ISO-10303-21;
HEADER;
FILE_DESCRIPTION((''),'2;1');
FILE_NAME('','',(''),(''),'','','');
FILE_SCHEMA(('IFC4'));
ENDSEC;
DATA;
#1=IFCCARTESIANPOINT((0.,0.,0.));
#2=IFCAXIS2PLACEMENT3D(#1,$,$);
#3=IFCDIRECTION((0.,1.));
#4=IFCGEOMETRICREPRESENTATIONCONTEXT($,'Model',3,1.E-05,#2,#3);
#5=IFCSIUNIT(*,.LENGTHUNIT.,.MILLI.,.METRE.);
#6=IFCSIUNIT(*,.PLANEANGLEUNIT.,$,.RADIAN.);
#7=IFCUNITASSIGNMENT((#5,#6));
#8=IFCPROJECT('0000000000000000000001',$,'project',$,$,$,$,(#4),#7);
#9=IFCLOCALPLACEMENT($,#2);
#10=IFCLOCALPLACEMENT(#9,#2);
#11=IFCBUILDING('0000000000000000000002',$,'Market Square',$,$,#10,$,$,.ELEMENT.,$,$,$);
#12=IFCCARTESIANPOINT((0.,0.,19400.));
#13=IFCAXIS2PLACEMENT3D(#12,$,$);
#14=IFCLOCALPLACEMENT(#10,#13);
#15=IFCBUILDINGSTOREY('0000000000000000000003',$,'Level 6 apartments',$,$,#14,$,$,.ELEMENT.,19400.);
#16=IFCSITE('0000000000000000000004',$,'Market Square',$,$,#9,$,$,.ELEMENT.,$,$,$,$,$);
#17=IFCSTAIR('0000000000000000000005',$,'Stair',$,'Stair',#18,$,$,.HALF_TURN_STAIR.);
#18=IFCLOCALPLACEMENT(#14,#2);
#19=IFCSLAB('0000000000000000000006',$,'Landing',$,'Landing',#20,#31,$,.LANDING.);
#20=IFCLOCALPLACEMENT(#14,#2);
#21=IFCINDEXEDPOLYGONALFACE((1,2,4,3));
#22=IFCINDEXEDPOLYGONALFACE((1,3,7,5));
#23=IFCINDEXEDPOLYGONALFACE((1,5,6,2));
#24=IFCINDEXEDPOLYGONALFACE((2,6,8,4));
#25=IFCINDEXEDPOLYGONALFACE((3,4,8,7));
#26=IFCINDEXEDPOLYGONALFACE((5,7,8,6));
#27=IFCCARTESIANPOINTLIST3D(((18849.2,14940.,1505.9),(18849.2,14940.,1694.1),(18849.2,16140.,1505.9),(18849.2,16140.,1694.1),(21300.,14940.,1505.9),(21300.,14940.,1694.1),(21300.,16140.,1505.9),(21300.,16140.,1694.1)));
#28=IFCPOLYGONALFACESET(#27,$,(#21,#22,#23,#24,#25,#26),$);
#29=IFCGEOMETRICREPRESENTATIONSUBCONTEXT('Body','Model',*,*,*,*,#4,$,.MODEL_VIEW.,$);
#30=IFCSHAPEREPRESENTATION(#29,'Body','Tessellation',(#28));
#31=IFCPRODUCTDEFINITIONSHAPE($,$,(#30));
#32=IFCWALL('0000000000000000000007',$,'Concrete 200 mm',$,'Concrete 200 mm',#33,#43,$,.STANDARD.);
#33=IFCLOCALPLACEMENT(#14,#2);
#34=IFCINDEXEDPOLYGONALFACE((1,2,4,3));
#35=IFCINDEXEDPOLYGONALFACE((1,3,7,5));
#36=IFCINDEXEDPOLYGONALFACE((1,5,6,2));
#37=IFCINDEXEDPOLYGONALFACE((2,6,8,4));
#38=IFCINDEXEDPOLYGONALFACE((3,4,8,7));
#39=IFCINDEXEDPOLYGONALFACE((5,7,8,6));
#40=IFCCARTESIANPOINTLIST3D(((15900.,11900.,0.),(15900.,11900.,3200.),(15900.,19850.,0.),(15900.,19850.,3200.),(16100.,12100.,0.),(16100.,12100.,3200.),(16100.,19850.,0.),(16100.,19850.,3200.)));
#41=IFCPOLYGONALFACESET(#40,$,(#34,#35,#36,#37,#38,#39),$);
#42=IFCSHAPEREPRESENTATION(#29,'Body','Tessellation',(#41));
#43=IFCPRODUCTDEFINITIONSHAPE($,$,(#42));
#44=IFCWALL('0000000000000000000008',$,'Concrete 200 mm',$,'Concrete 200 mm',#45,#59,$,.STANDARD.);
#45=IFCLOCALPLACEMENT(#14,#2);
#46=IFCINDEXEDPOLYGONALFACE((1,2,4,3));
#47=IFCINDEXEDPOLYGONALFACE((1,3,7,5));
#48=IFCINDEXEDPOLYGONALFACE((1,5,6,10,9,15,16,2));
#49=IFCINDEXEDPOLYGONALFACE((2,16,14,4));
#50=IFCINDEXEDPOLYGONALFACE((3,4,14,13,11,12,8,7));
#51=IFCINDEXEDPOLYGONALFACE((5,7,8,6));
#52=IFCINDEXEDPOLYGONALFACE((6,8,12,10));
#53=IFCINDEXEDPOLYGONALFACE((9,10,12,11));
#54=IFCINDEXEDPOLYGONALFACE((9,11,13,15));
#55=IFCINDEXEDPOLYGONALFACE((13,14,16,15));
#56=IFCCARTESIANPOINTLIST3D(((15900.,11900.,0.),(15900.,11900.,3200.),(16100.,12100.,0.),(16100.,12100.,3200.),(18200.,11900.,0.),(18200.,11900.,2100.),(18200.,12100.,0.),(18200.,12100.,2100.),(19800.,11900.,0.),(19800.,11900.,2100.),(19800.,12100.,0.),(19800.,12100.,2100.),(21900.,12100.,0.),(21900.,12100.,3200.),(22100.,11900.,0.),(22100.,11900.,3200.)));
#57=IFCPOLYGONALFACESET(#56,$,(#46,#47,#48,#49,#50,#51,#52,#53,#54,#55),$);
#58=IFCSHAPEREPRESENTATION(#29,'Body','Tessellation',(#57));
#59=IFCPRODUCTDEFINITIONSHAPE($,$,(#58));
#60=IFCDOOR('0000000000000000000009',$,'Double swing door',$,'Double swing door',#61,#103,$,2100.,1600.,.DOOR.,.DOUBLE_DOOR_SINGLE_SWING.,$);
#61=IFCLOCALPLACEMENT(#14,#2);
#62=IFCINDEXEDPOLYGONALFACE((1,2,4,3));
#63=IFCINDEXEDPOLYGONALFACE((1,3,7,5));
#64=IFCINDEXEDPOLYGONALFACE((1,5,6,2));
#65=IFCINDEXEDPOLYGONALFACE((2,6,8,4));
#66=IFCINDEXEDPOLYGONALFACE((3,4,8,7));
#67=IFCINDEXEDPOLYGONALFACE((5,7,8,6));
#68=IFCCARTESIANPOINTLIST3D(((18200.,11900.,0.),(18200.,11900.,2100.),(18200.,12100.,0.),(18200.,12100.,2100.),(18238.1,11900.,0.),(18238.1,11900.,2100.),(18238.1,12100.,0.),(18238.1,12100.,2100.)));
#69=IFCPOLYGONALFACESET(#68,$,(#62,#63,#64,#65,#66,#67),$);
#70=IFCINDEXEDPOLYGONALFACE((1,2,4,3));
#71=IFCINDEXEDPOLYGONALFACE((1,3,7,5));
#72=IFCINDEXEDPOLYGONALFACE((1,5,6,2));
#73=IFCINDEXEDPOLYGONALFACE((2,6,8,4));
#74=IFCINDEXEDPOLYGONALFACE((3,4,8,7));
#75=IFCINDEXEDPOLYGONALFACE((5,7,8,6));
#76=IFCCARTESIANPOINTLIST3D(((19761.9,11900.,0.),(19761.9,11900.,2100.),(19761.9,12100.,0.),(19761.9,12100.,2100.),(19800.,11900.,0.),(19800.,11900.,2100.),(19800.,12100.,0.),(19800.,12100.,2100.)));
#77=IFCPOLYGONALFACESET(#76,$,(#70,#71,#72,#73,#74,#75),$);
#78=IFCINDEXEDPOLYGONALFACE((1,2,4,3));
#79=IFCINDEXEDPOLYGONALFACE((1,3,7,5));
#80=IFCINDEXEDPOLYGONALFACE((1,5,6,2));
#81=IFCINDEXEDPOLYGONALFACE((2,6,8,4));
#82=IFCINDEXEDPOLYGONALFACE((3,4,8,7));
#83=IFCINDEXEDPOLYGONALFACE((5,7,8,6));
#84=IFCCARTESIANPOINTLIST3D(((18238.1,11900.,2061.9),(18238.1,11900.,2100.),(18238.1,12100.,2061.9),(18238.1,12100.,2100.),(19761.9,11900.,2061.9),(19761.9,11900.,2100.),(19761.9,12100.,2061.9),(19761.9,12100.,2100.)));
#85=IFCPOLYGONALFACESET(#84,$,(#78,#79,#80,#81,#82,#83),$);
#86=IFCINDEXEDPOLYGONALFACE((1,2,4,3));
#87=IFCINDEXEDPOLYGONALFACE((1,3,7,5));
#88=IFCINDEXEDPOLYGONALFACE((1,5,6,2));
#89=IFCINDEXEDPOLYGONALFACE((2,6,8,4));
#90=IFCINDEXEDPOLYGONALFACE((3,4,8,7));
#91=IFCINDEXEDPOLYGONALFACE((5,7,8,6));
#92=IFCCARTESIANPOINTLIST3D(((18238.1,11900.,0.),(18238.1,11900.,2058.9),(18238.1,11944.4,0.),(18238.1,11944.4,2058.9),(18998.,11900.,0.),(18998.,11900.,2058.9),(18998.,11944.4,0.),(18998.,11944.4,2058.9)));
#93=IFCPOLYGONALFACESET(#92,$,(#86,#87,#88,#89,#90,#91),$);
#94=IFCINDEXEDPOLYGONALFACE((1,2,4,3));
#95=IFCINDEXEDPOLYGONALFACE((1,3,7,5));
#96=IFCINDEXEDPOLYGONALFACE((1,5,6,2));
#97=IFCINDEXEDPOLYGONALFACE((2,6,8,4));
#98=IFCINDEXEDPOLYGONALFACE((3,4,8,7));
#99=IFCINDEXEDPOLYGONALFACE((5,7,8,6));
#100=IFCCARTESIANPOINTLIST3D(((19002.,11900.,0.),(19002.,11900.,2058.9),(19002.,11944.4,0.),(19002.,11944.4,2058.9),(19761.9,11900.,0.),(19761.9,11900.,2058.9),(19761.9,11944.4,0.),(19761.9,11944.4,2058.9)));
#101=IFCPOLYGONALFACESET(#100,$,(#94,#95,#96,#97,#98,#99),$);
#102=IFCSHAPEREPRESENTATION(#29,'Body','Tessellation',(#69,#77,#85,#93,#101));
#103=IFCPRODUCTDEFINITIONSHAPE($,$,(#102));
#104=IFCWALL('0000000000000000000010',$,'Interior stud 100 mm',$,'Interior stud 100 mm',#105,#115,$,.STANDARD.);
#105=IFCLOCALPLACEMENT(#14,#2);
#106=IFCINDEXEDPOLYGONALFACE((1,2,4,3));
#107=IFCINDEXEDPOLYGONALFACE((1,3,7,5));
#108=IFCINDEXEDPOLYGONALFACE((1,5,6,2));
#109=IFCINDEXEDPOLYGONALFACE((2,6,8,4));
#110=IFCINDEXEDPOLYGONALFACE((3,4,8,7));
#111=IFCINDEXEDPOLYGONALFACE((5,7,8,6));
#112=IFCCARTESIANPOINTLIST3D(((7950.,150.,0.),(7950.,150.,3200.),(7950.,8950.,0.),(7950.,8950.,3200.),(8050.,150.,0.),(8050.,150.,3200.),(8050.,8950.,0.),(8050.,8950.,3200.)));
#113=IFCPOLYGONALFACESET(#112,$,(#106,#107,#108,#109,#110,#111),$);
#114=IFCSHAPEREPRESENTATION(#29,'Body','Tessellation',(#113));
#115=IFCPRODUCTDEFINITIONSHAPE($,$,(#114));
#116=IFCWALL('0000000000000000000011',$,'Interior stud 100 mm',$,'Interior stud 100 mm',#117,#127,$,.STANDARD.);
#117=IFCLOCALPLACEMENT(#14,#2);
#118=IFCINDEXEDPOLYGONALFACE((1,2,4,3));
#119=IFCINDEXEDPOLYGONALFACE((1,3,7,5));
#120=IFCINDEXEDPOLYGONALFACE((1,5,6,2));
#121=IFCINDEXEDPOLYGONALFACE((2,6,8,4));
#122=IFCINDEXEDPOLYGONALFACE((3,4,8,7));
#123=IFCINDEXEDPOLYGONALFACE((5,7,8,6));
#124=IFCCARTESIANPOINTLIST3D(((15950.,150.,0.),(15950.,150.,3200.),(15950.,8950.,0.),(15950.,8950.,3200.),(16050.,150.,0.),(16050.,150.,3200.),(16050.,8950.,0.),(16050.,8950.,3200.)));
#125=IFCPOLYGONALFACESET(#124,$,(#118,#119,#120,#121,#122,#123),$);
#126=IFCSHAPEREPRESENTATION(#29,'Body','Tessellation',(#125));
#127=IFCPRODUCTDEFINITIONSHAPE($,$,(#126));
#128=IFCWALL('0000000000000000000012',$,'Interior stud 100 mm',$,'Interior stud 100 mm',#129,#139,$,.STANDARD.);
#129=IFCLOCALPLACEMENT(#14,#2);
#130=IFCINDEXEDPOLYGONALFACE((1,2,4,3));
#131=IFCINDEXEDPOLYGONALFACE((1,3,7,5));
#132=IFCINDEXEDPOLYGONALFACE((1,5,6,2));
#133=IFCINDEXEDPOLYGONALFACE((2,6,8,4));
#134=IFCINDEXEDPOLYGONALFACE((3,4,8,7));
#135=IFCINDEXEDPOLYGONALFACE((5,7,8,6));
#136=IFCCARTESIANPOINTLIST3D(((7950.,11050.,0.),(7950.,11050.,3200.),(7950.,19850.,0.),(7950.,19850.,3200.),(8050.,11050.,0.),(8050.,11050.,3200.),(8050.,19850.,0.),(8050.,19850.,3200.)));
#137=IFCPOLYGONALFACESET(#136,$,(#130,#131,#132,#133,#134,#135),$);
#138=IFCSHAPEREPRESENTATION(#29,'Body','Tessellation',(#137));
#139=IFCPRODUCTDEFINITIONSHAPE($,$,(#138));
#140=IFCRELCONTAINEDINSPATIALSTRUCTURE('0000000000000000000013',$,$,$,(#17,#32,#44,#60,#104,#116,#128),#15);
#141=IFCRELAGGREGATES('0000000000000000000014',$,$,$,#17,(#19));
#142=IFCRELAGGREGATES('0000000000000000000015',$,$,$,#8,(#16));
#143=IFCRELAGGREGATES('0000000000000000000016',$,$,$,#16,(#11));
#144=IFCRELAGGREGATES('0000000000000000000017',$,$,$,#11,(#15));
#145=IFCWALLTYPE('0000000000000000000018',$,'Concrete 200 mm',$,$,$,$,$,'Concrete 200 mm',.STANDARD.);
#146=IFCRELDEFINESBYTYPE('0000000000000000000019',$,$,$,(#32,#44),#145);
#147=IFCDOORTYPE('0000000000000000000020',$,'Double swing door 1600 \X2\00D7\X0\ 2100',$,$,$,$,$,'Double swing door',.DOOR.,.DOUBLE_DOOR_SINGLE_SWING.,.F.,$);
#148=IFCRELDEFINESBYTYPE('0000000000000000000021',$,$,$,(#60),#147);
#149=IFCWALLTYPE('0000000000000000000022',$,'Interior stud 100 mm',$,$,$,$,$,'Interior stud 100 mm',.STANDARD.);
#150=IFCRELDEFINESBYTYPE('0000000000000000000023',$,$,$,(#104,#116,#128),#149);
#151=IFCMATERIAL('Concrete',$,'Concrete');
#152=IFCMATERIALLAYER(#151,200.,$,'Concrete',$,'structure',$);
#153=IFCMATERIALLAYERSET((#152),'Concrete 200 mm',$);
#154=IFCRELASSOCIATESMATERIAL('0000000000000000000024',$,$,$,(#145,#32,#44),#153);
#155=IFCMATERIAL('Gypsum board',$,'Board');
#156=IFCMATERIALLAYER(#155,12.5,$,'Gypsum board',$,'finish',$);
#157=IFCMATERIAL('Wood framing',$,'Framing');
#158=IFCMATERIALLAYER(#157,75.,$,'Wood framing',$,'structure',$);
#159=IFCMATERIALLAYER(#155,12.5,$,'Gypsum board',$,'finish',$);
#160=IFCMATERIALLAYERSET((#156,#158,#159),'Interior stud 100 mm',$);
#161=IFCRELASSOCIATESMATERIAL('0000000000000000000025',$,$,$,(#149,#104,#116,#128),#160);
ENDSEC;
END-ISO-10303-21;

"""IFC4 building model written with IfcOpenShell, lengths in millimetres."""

from ifc_helpers import new_model, si_unit, direction, frame, origin, origin_with_axes, place, context, subcontext, project, spatial, polyline, outline, extrude, material, layer, layer_set, layer_usage, type_object, element, fill, aggregate, save


model = new_model("IFC4")

# Units and contexts
model_context = context("Model", 3, precision=1e-05, world=origin(), true_north=direction((0.0, 1.0)))
body_context = subcontext(model_context, "Body", "Model", "MODEL_VIEW")
ifc_project = project(units=[si_unit("LENGTHUNIT", "METRE", prefix="MILLI"), si_unit("PLANEANGLEUNIT", "RADIAN")], contexts=[model_context])

# Site, building, storey
site_placement = place(None, origin())
site = spatial("IfcSite", under=ifc_project, at=site_placement, Name="Market Square", CompositionType="ELEMENT")
building_placement = place(site_placement, origin())
building = spatial("IfcBuilding", under=site, at=building_placement, Name="Market Square", CompositionType="ELEMENT")
storey_placement = place(building_placement, frame((0.0, 0.0, 19400.0)))
storey = spatial("IfcBuildingStorey", under=building, at=storey_placement, Name="Level 6 apartments", CompositionType="ELEMENT", Elevation=19400.0)

# Stair, slab
stair_placement = place(storey_placement, origin_with_axes())
stair = element("IfcStair", 1, at=stair_placement, inside=storey, Name="Stair", ObjectType="Stair", PredefinedType="HALF_TURN_STAIR")
slab_placement = place(storey_placement, origin_with_axes())
slab = element("IfcSlab", 2, at=slab_placement, Name="Landing", ObjectType="Landing", PredefinedType="LANDING", context=body_context, shape_type="SweptSolid", body=[
    extrude(outline(polyline([(21300.0, 14940.0), (21300.0, 16140.0), (18849.2, 16140.0), (18849.2, 14940.0), (21300.0, 14940.0)])), frame((0.0, 0.0, 1505.9)), (0.0, 0.0, 1.0), 188.2),
])

# Wall
ifc_material_1 = material(Name="Concrete", Category="Concrete")
ifc_layer_1 = layer(ifc_material_1, 200.0, Name="Concrete", Category="structure")
ifc_layer_set_1 = layer_set([ifc_layer_1], Name="Concrete 200 mm")
ifc_layer_usage_1 = layer_usage(ifc_layer_set_1, "AXIS2", "NEGATIVE", 100.0)
wall_type_1 = type_object("IfcWallType", Name="Concrete 200 mm", ElementType="Concrete 200 mm", PredefinedType="STANDARD", material=ifc_layer_set_1)
wall_1_placement = place(storey_placement, frame((16000.0, 12000.0, 0.0), z_axis=(0.0, 0.0, 1.0), x_axis=(0.0, 1.0, 0.0)))
element("IfcWall", 3, at=wall_1_placement, inside=storey, type_object=wall_type_1, material=ifc_layer_usage_1, Name="Concrete 200 mm", ObjectType="Concrete 200 mm", PredefinedType="STANDARD", context=body_context, shape_type="SweptSolid", body=[
    extrude(outline(polyline([(100.0, -100.0), (7850.0, -100.0), (7850.0, 100.0), (-100.0, 100.0), (100.0, -100.0)])), origin(), (0.0, 0.0, 1.0), 3200.0),
])

# Wall, opening, door
ifc_layer_usage_2 = layer_usage(ifc_layer_set_1, "AXIS2", "NEGATIVE", 100.0)
wall_2_placement = place(storey_placement, frame((16000.0, 12000.0, 0.0), z_axis=(0.0, 0.0, 1.0), x_axis=(1.0, 0.0, 0.0)))
wall_2 = element("IfcWall", 4, at=wall_2_placement, inside=storey, type_object=wall_type_1, material=ifc_layer_usage_2, Name="Concrete 200 mm", ObjectType="Concrete 200 mm", PredefinedType="STANDARD", context=body_context, shape_type="SweptSolid", body=[
    extrude(outline(polyline([(-100.0, -100.0), (6100.0, -100.0), (5900.0, 100.0), (100.0, 100.0), (-100.0, -100.0)])), origin(), (0.0, 0.0, 1.0), 3200.0),
])
opening_placement = place(wall_2_placement, frame((2200.0, 0.0, 0.0), z_axis=(0.0, 0.0, 1.0), x_axis=(1.0, 0.0, 0.0)))
opening = element("IfcOpeningElement", 5, at=opening_placement, cuts=wall_2, PredefinedType="OPENING", context=body_context, shape_type="SweptSolid", body=[
    extrude(outline(polyline([(0.0, -110.0), (1600.0, -110.0), (1600.0, 110.0), (0.0, 110.0), (0.0, -110.0)])), origin(), (0.0, 0.0, 1.0), 2100.0),
])
door_type = type_object("IfcDoorType", Name="Double swing door 1600 × 2100", ElementType="Double swing door", OperationType="DOUBLE_DOOR_SINGLE_SWING", ParameterTakesPrecedence=False, PredefinedType="DOOR")
door_placement = place(opening_placement, origin_with_axes())
door = element("IfcDoor", 6, at=door_placement, inside=storey, type_object=door_type, Name="Double swing door", ObjectType="Double swing door", OperationType="DOUBLE_DOOR_SINGLE_SWING", OverallHeight=2100.0, OverallWidth=1600.0, PredefinedType="DOOR", context=body_context, shape_type="SweptSolid", body=[
    extrude(outline(polyline([(0.0, -100.0), (38.1, -100.0), (38.1, 100.0), (0.0, 100.0), (0.0, -100.0)])), origin(), (0.0, 0.0, 1.0), 2100.0),
    extrude(outline(polyline([(1561.9, -100.0), (1600.0, -100.0), (1600.0, 100.0), (1561.9, 100.0), (1561.9, -100.0)])), origin(), (0.0, 0.0, 1.0), 2100.0),
    extrude(outline(polyline([(38.1, -100.0), (1561.9, -100.0), (1561.9, 100.0), (38.1, 100.0), (38.1, -100.0)])), frame((0.0, 0.0, 2061.9)), (0.0, 0.0, 1.0), 38.1),
    extrude(outline(polyline([(38.1, -100.0), (798.0, -100.0), (798.0, -55.5), (38.1, -55.5), (38.1, -100.0)])), origin(), (0.0, 0.0, 1.0), 2058.9),
    extrude(outline(polyline([(802.0, -100.0), (1561.9, -100.0), (1561.9, -55.5), (802.0, -55.5), (802.0, -100.0)])), origin(), (0.0, 0.0, 1.0), 2058.9),
])
fill(opening, door)

# Walls
ifc_material_2 = material(Name="Gypsum board", Category="Board")
ifc_layer_2 = layer(ifc_material_2, 12.5, Name="Gypsum board", Category="finish")
ifc_material_3 = material(Name="Wood framing", Category="Framing")
ifc_layer_3 = layer(ifc_material_3, 75.0, Name="Wood framing", Category="structure")
ifc_layer_4 = layer(ifc_material_2, 12.5, Name="Gypsum board", Category="finish")
ifc_layer_set_2 = layer_set([ifc_layer_2, ifc_layer_3, ifc_layer_4], Name="Interior stud 100 mm")
ifc_layer_usage_3 = layer_usage(ifc_layer_set_2, "AXIS2", "NEGATIVE", 50.0)
wall_type_2 = type_object("IfcWallType", Name="Interior stud 100 mm", ElementType="Interior stud 100 mm", PredefinedType="STANDARD", material=ifc_layer_set_2)
wall_3_placement = place(storey_placement, frame((8000.0, 0.0, 0.0), z_axis=(0.0, 0.0, 1.0), x_axis=(0.0, 1.0, 0.0)))
element("IfcWall", 7, at=wall_3_placement, inside=storey, type_object=wall_type_2, material=ifc_layer_usage_3, Name="Interior stud 100 mm", ObjectType="Interior stud 100 mm", PredefinedType="STANDARD", context=body_context, shape_type="SweptSolid", body=[
    extrude(outline(polyline([(150.0, -50.0), (8950.0, -50.0), (8950.0, 50.0), (150.0, 50.0), (150.0, -50.0)])), origin(), (0.0, 0.0, 1.0), 3200.0),
])
ifc_layer_usage_4 = layer_usage(ifc_layer_set_2, "AXIS2", "NEGATIVE", 50.0)
wall_4_placement = place(storey_placement, frame((16000.0, 0.0, 0.0), z_axis=(0.0, 0.0, 1.0), x_axis=(0.0, 1.0, 0.0)))
element("IfcWall", 8, at=wall_4_placement, inside=storey, type_object=wall_type_2, material=ifc_layer_usage_4, Name="Interior stud 100 mm", ObjectType="Interior stud 100 mm", PredefinedType="STANDARD", context=body_context, shape_type="SweptSolid", body=[
    extrude(outline(polyline([(150.0, -50.0), (8950.0, -50.0), (8950.0, 50.0), (150.0, 50.0), (150.0, -50.0)])), origin(), (0.0, 0.0, 1.0), 3200.0),
])
ifc_layer_usage_5 = layer_usage(ifc_layer_set_2, "AXIS2", "NEGATIVE", 50.0)
wall_5_placement = place(storey_placement, frame((8000.0, 11000.0, 0.0), z_axis=(0.0, 0.0, 1.0), x_axis=(0.0, 1.0, 0.0)))
element("IfcWall", 9, at=wall_5_placement, inside=storey, type_object=wall_type_2, material=ifc_layer_usage_5, Name="Interior stud 100 mm", ObjectType="Interior stud 100 mm", PredefinedType="STANDARD", context=body_context, shape_type="SweptSolid", body=[
    extrude(outline(polyline([(50.0, -50.0), (8850.0, -50.0), (8850.0, 50.0), (50.0, 50.0), (50.0, -50.0)])), origin(), (0.0, 0.0, 1.0), 3200.0),
])

aggregate(stair, [slab])

save(model, "model.ifc")
